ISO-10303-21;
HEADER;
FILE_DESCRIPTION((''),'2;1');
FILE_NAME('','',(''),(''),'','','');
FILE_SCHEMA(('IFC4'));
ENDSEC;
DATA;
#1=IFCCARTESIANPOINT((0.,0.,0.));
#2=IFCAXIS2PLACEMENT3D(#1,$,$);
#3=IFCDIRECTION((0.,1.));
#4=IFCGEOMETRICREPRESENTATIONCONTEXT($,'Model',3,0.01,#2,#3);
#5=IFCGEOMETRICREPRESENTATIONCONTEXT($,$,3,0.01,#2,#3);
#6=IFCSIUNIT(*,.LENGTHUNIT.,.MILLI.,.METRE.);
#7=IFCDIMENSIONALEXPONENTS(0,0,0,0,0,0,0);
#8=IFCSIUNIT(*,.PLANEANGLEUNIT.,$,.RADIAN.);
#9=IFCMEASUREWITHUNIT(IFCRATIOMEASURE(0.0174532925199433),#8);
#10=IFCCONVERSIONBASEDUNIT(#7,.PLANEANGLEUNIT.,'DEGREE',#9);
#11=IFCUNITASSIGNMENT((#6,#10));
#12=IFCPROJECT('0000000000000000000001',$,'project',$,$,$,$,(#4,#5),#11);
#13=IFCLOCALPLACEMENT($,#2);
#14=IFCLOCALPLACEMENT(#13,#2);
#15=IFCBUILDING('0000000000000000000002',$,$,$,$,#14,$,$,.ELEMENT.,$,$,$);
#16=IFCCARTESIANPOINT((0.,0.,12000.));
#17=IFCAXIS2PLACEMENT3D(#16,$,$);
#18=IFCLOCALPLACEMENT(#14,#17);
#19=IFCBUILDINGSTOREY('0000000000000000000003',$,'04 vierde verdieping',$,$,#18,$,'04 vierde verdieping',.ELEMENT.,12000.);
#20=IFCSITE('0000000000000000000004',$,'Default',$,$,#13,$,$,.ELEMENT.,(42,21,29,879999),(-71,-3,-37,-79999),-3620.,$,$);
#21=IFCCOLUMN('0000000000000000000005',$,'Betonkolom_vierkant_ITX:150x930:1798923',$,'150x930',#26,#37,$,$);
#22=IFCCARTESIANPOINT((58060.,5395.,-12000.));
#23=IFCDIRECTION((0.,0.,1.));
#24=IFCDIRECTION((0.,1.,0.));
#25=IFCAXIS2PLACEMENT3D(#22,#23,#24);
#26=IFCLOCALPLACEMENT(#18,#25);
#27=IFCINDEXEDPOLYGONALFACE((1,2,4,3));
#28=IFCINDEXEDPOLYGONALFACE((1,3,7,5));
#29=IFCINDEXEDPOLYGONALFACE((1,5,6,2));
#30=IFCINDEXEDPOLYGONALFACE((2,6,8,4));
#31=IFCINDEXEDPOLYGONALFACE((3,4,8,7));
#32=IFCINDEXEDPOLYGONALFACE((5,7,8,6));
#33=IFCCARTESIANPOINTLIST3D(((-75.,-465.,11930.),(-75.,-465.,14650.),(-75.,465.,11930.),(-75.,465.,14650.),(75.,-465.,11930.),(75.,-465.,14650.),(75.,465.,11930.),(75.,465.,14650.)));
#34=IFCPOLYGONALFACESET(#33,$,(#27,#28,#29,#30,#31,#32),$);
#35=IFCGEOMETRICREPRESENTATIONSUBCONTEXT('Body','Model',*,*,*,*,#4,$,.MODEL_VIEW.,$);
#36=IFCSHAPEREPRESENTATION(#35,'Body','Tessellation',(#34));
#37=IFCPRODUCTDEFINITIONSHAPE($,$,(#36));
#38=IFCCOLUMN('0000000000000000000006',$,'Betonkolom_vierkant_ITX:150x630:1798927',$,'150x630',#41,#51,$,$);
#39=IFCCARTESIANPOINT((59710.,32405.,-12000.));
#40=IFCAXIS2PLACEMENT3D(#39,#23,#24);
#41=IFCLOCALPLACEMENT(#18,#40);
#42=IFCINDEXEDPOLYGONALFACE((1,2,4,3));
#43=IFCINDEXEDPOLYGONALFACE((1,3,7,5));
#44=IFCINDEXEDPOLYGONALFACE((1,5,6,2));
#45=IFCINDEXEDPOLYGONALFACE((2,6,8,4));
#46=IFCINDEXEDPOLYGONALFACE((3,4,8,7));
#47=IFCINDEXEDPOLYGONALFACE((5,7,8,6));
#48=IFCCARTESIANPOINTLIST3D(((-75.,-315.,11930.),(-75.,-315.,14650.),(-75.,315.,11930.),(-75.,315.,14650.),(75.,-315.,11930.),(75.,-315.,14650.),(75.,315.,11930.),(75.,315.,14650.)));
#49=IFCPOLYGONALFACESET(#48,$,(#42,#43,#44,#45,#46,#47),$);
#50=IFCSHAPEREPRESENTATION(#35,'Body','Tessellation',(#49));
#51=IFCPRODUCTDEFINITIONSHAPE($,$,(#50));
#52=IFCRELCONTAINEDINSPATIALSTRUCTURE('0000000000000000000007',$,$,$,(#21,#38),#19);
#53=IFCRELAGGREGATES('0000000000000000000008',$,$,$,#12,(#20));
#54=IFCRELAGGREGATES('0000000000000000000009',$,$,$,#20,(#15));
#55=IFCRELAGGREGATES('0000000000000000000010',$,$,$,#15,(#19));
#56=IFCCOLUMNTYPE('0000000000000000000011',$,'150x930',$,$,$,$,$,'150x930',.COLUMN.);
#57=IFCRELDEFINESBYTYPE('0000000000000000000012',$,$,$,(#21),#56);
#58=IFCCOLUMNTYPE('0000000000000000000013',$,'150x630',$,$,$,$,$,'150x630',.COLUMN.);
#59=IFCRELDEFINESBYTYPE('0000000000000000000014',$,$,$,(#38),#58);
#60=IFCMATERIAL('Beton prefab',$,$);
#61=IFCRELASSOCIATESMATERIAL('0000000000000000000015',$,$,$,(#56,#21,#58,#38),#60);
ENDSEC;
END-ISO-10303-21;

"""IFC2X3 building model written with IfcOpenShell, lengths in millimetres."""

from ifc_helpers import new_model, entity, si_unit, converted_unit, direction, frame, origin, origin_2d_with_axis, place, context, subcontext, project, spatial, rectangle, extrude, source, transform, mapped, material, type_object, type_shapes, element, save


model = new_model("IFC2X3")

# Units and contexts
model_context = context("Model", 3, precision=0.01, world=origin(), true_north=direction((0.0, 1.0)))
context_of_model = context(None, 3, precision=0.01, world=origin(), true_north=direction((0.0, 1.0)))
body_context = subcontext(model_context, "Body", "Model", "MODEL_VIEW")
ifc_project = project(units=[si_unit("LENGTHUNIT", "METRE", prefix="MILLI"), converted_unit("PLANEANGLEUNIT", "DEGREE", entity("IfcRatioMeasure", 0.0174532925199433), si_unit("PLANEANGLEUNIT", "RADIAN"), dimensions=[0, 0, 0, 0, 0, 0, 0])], contexts=[model_context, context_of_model])

# Site, building, storey
site_placement = place(None, origin())
site = spatial("IfcSite", under=ifc_project, at=site_placement, Name="Default", CompositionType="ELEMENT", RefLatitude=(42, 21, 29, 879999), RefLongitude=(-71, -3, -37, -79999), RefElevation=-3620.0)
building_placement = place(site_placement, origin())
building = spatial("IfcBuilding", under=site, at=building_placement, CompositionType="ELEMENT")
storey_placement = place(building_placement, frame((0.0, 0.0, 12000.0)))
storey = spatial("IfcBuildingStorey", under=building, at=storey_placement, Name="04 vierde verdieping", LongName="04 vierde verdieping", CompositionType="ELEMENT", Elevation=12000.0)

# Columns
ifc_material_1 = material(Name="Beton prefab")
column_type_1 = type_object("IfcColumnType", Name="150x930", ElementType="150x930", PredefinedType="COLUMN", material=ifc_material_1)
shared_shape_1 = source(origin(), body_context, "Body", "SweptSolid", [
    extrude(rectangle(XDim=930.0, YDim=150.0, at=origin_2d_with_axis()), frame((0.0, 0.0, 11930.0), z_axis=(0.0, 0.0, 1.0), x_axis=(0.0, -1.0, 0.0)), (0.0, 0.0, 1.0), 2720.0),
])
type_shapes(column_type_1, [shared_shape_1])
column_1_placement = place(storey_placement, frame((58060.0, 5395.0, -12000.0), z_axis=(0.0, 0.0, 1.0), x_axis=(0.0, 1.0, 0.0)))
element("IfcColumn", 1, at=column_1_placement, inside=storey, type_object=column_type_1, material=ifc_material_1, Name="Betonkolom_vierkant_ITX:150x930:1798923", ObjectType="150x930", context=body_context, shape_type="MappedRepresentation", body=[
    mapped(shared_shape_1, transform((0.0, 0.0, 0.0), scale=1.0)),
])
column_type_2 = type_object("IfcColumnType", Name="150x630", ElementType="150x630", PredefinedType="COLUMN", material=ifc_material_1)
shared_shape_2 = source(origin(), body_context, "Body", "SweptSolid", [
    extrude(rectangle(XDim=630.0, YDim=150.0, at=origin_2d_with_axis()), frame((0.0, 0.0, 11930.0), z_axis=(0.0, 0.0, 1.0), x_axis=(0.0, -1.0, 0.0)), (0.0, 0.0, 1.0), 2720.0),
])
type_shapes(column_type_2, [shared_shape_2])
column_2_placement = place(storey_placement, frame((59710.0, 32405.0, -12000.0), z_axis=(0.0, 0.0, 1.0), x_axis=(0.0, 1.0, 0.0)))
element("IfcColumn", 2, at=column_2_placement, inside=storey, type_object=column_type_2, material=ifc_material_1, Name="Betonkolom_vierkant_ITX:150x630:1798927", ObjectType="150x630", context=body_context, shape_type="MappedRepresentation", body=[
    mapped(shared_shape_2, transform((0.0, 0.0, 0.0), scale=1.0)),
])

save(model, "model.ifc")
